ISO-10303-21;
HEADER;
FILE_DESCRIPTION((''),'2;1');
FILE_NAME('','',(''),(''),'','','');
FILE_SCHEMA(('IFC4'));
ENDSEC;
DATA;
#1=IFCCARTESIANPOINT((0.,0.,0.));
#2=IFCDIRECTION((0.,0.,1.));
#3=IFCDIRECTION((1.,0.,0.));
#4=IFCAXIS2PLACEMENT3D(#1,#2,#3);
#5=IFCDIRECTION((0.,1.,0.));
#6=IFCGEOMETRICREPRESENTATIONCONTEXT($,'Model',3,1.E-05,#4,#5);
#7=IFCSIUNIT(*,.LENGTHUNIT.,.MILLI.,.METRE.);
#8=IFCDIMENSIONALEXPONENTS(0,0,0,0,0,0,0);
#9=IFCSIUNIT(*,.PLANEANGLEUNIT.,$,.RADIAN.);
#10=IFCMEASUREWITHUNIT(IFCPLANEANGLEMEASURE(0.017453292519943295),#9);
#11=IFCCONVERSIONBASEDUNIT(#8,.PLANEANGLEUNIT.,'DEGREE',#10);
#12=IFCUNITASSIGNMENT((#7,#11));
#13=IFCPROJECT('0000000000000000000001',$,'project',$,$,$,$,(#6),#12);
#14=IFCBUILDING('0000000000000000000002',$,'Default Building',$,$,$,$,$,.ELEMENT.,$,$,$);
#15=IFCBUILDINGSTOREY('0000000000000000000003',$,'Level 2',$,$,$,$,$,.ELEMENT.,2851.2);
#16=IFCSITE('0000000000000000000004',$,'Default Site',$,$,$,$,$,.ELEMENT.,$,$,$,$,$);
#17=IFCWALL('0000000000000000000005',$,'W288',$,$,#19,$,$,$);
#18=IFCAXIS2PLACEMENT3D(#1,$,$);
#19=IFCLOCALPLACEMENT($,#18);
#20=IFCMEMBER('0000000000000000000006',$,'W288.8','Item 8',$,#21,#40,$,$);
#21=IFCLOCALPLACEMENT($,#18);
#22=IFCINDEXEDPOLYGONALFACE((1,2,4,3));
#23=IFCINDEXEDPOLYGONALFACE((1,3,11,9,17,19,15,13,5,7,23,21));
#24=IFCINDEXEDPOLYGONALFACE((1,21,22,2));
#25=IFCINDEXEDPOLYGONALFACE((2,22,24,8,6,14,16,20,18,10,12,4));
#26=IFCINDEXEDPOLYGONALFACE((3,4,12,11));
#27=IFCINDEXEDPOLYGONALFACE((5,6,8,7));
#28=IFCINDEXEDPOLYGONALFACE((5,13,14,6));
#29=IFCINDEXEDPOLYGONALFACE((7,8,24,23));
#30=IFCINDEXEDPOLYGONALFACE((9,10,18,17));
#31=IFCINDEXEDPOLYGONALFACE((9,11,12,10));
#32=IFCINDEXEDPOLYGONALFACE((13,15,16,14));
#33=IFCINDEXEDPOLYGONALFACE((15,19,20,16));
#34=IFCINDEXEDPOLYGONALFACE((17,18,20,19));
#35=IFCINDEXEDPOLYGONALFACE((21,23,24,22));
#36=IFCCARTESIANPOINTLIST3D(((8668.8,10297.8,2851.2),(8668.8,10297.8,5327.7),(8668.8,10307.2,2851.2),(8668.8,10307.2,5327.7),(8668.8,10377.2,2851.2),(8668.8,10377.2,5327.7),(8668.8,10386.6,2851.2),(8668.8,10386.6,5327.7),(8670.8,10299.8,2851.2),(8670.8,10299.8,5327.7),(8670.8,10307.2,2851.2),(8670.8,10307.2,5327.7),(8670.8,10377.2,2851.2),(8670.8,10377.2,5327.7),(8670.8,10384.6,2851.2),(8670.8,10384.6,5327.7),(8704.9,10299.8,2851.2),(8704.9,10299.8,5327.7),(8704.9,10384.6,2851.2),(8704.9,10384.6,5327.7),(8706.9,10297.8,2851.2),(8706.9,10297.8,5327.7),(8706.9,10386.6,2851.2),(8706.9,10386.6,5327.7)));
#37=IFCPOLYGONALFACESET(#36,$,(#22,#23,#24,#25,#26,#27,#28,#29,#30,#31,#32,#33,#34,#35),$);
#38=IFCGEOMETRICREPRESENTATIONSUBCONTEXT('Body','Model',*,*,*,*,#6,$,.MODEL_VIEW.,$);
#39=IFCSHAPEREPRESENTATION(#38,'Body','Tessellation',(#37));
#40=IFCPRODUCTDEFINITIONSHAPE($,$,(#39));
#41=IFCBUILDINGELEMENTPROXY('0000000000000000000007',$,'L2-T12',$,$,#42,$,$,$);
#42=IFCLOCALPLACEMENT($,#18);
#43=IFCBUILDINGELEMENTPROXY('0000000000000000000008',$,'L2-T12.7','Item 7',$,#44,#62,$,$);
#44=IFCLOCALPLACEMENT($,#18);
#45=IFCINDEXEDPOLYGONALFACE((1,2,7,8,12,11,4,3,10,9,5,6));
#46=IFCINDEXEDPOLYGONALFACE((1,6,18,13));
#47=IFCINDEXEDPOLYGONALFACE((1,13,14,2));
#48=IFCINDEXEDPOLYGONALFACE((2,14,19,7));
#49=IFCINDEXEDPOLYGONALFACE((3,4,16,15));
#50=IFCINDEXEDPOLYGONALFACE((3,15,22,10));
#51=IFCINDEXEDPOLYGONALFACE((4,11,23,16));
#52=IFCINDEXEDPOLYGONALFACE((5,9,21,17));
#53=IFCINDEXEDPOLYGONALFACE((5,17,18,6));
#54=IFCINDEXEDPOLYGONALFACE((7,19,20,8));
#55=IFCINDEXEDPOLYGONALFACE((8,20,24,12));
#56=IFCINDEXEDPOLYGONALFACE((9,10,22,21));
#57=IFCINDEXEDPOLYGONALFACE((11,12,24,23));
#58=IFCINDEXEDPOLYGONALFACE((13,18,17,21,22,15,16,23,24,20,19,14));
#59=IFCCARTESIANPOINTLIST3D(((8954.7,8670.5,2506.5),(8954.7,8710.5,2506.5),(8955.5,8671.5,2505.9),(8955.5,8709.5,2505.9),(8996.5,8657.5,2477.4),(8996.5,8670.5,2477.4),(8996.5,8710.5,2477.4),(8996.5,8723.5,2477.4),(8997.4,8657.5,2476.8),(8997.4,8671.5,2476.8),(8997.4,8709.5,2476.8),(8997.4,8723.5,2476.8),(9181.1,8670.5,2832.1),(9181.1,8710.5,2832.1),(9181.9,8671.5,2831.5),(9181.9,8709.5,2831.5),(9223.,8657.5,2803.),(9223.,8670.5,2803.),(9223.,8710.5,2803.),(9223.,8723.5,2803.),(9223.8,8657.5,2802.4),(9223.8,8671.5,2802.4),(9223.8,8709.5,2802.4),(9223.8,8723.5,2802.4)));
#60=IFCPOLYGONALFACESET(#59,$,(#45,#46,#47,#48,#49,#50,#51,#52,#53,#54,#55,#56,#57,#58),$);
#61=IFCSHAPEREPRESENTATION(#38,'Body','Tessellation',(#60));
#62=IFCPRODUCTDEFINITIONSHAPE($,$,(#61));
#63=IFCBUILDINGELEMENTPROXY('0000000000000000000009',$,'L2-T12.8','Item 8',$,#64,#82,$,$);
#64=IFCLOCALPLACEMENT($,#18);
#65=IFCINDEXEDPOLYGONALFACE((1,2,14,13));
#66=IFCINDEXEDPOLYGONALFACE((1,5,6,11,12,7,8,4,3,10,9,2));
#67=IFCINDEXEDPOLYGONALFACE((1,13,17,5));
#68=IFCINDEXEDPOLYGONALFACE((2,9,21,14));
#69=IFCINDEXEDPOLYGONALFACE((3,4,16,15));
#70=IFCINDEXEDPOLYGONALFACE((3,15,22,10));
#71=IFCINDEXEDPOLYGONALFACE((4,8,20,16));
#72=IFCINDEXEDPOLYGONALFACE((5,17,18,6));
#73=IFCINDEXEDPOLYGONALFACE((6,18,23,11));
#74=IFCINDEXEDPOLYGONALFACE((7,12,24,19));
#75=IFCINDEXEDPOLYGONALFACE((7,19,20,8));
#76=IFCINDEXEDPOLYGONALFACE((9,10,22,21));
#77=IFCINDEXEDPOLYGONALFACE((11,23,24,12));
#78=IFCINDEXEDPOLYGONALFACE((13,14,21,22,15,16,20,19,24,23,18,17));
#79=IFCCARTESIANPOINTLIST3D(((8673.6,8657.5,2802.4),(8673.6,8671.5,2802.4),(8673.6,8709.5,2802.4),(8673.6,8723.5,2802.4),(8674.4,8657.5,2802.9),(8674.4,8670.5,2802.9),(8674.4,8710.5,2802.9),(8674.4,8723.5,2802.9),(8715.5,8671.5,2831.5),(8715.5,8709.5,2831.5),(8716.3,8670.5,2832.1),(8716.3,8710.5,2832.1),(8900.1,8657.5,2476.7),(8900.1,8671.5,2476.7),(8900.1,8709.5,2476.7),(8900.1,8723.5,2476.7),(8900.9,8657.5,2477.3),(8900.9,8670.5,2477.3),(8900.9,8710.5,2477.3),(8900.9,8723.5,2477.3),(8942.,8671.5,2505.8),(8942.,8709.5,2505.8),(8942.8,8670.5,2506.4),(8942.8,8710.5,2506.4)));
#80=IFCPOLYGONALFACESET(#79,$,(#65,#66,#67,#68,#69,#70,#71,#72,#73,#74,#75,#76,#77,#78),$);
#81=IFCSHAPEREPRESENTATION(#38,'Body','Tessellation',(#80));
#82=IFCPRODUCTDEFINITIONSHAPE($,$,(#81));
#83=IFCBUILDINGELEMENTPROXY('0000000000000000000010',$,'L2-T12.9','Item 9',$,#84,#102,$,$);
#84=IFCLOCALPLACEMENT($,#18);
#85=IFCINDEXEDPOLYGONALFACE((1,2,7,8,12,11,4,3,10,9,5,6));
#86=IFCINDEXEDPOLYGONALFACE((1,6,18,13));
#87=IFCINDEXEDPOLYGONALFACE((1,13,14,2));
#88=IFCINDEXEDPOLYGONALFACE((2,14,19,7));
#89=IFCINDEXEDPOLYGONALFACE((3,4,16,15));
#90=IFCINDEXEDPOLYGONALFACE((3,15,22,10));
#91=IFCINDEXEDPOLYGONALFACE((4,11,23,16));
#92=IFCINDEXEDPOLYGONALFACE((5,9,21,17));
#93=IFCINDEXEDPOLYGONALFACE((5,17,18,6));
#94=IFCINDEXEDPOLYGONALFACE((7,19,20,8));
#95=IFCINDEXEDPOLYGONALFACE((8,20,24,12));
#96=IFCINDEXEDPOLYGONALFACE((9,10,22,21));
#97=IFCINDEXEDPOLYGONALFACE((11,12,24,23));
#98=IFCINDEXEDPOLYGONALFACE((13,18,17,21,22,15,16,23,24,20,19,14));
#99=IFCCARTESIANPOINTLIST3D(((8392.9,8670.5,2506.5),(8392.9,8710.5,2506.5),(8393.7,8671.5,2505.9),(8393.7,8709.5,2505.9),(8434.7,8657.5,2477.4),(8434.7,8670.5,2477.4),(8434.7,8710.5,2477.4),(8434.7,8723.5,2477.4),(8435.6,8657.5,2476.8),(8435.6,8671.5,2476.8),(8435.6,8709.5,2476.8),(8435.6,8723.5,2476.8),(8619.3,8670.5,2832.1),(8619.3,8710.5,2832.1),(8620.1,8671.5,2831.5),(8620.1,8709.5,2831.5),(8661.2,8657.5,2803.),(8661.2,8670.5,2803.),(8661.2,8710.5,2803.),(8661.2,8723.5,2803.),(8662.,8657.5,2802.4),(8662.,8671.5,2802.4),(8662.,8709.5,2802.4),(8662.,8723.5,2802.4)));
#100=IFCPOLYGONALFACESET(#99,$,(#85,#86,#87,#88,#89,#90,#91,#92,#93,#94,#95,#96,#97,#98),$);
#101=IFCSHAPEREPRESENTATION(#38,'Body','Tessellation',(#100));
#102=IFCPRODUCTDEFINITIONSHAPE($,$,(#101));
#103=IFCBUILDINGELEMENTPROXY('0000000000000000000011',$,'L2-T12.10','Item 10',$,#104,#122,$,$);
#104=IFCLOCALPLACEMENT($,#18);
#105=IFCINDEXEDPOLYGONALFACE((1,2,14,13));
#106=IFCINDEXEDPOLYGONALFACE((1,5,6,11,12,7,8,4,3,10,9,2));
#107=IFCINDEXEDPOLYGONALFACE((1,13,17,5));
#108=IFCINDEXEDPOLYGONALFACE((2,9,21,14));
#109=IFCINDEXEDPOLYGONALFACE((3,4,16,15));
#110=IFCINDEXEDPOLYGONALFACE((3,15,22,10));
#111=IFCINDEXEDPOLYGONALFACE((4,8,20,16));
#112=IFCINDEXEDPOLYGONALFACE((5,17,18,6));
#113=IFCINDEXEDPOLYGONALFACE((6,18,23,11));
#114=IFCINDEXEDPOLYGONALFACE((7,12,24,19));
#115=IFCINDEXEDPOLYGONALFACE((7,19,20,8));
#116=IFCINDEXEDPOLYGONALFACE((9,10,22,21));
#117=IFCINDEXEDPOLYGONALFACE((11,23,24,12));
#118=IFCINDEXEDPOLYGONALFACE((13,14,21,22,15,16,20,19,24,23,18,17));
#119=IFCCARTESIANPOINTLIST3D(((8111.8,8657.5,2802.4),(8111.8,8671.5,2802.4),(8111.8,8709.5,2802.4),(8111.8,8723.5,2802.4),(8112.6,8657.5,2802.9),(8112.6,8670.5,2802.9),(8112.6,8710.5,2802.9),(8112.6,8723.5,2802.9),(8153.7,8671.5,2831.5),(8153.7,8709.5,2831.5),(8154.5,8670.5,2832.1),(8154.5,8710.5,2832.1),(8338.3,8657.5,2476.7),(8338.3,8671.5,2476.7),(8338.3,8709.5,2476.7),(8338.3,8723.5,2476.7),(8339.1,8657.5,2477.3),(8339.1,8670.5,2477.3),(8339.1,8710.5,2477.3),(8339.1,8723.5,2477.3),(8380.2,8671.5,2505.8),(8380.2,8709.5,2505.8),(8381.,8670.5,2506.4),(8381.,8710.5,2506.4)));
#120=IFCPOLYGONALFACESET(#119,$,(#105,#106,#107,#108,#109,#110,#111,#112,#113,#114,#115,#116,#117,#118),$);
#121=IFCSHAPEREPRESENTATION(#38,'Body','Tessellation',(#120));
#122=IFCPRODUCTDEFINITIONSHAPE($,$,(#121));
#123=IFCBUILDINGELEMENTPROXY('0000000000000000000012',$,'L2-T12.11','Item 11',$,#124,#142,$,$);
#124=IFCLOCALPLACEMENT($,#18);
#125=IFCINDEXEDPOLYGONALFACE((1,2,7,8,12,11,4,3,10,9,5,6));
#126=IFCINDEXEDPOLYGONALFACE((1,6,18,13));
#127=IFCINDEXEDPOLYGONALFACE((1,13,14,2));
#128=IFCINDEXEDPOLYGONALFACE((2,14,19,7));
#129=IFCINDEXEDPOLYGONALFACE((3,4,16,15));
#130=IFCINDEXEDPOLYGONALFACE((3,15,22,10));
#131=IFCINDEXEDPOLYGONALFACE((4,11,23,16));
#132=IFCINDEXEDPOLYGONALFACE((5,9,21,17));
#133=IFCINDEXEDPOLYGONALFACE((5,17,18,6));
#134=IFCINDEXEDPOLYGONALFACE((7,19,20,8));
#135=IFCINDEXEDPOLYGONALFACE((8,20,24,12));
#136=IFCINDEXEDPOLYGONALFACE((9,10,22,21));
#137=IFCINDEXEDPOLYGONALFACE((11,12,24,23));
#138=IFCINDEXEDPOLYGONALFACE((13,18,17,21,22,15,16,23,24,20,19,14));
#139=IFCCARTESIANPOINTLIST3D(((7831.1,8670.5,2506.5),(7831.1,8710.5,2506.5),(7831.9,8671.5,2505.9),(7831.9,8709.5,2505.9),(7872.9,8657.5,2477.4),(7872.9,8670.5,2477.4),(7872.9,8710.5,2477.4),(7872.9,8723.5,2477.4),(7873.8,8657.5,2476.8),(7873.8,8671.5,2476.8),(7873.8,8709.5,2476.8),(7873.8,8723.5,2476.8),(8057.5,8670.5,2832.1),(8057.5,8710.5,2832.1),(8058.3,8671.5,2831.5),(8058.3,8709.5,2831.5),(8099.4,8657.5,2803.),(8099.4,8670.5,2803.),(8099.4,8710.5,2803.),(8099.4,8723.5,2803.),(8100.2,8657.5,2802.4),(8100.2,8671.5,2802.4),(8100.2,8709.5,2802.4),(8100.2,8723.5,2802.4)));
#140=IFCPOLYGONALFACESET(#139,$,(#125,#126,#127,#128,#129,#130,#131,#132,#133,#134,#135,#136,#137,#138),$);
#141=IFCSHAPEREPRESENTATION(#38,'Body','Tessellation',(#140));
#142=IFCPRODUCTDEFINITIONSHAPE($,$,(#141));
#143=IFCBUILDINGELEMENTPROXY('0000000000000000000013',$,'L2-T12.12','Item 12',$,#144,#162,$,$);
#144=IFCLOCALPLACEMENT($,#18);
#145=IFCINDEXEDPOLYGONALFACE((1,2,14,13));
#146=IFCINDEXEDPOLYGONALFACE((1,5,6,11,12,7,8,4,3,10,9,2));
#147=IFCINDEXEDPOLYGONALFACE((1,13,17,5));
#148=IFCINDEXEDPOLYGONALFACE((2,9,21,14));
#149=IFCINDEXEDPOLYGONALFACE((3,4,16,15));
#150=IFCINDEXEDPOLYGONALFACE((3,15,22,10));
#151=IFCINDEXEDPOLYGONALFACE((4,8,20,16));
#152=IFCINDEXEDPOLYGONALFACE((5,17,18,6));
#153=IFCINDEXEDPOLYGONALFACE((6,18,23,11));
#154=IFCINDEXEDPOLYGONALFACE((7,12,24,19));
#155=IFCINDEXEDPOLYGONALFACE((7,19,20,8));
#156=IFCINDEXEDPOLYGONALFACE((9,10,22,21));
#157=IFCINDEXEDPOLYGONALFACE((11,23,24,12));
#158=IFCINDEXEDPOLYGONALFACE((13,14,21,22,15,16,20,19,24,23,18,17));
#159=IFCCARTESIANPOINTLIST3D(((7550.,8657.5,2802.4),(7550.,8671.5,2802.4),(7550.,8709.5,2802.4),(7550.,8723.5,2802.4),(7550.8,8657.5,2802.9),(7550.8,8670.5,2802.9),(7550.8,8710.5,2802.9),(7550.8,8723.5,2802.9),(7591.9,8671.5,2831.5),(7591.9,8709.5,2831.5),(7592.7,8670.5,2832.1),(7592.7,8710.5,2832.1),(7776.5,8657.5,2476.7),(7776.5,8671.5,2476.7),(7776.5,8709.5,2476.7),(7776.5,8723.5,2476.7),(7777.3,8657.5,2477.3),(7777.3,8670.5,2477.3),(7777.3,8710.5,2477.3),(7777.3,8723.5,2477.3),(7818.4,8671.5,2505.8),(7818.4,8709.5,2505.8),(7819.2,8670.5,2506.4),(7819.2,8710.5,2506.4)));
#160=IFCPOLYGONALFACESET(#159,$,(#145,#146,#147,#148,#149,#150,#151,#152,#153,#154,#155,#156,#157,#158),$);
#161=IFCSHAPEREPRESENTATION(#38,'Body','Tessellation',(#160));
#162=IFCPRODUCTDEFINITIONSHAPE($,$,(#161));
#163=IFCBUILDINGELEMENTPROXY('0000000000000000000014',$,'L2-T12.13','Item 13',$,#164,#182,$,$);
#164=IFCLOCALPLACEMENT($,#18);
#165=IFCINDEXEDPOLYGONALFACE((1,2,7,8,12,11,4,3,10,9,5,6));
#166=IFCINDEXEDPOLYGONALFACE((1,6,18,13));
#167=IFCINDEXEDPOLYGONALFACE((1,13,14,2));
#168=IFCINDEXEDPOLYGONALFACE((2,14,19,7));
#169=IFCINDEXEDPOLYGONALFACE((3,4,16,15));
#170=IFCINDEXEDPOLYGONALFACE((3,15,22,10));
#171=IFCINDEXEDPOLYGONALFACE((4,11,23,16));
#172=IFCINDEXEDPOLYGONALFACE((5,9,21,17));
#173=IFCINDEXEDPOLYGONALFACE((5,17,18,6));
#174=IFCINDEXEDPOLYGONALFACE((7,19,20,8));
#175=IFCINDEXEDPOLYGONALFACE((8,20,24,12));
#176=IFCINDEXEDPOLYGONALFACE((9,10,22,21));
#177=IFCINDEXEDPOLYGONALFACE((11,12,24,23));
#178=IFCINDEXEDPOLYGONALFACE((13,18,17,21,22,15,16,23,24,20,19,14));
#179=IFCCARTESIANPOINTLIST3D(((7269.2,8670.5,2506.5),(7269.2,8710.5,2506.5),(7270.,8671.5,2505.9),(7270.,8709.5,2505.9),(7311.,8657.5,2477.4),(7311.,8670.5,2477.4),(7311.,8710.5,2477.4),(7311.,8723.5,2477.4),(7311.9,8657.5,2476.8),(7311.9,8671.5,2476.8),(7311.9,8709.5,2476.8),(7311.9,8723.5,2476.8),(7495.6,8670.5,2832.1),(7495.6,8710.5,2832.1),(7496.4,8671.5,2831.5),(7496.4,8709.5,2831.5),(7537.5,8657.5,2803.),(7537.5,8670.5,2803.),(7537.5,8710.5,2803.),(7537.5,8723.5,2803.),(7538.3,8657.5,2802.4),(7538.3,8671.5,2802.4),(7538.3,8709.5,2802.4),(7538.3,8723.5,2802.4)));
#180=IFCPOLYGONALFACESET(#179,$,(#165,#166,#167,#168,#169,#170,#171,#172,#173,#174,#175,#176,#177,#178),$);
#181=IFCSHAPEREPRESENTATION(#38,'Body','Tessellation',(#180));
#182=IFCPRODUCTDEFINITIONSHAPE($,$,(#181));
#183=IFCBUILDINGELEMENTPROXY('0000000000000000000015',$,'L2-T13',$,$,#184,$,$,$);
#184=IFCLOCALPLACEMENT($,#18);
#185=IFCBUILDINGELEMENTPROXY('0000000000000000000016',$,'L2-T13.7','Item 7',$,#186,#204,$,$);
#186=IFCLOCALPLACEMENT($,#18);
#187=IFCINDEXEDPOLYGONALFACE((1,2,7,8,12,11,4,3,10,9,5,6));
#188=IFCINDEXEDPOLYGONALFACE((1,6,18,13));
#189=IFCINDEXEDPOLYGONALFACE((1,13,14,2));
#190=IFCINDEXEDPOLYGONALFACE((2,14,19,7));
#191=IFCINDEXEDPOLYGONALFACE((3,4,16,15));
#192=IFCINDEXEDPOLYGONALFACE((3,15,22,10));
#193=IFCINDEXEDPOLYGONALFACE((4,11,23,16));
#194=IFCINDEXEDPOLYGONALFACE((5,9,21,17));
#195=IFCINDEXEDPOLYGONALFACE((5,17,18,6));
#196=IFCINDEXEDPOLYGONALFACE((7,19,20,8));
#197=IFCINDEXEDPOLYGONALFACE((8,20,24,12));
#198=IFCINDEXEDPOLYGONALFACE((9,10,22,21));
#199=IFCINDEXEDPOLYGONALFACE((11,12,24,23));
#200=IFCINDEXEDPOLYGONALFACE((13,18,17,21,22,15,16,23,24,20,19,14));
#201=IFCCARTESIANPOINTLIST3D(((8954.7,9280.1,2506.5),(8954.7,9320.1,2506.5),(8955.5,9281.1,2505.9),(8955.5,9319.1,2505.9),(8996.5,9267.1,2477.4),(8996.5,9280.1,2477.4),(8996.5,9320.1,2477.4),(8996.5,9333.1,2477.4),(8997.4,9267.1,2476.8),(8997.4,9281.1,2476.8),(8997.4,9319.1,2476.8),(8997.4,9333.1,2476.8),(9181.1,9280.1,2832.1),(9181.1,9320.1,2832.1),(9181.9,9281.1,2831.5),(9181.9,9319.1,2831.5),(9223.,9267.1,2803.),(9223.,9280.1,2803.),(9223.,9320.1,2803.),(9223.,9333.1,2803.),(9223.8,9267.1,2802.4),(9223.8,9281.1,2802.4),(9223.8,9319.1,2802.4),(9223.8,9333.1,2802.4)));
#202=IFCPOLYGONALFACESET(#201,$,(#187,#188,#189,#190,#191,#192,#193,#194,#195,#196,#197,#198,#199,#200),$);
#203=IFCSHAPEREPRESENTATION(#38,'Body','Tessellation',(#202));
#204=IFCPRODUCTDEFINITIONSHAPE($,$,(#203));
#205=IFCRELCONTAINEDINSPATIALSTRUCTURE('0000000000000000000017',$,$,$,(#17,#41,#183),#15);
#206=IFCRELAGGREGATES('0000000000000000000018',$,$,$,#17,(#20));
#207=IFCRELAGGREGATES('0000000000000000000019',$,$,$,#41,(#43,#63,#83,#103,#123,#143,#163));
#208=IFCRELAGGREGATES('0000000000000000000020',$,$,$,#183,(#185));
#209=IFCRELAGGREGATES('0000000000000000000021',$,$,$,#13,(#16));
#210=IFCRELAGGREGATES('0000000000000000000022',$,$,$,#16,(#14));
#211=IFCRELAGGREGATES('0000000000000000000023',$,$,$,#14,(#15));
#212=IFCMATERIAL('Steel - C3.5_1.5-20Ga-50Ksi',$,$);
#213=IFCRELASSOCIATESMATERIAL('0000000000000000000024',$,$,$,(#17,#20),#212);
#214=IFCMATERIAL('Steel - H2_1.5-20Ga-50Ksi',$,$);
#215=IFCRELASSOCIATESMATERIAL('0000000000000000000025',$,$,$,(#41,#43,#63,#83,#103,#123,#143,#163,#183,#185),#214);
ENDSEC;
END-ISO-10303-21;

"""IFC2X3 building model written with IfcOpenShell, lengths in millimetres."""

from ifc_helpers import new_model, entity, si_unit, converted_unit, direction, frame, origin, origin_with_axes, origin_2d_with_axis, place, context, subcontext, project, spatial, polyline, c_section, outline, extrude, material, element, aggregate, save


model = new_model("IFC2X3")

# Units and contexts
model_context = context("Model", 3, precision=1e-05, world=origin_with_axes(), true_north=direction((0.0, 1.0, 0.0)))
body_context = subcontext(model_context, "Body", "Model", "MODEL_VIEW")
ifc_project = project(units=[si_unit("LENGTHUNIT", "METRE", prefix="MILLI"), converted_unit("PLANEANGLEUNIT", "DEGREE", entity("IfcPlaneAngleMeasure", 0.017453292519943295), si_unit("PLANEANGLEUNIT", "RADIAN"), dimensions=[0, 0, 0, 0, 0, 0, 0])], contexts=[model_context])

# Site, building, storey
site = spatial("IfcSite", under=ifc_project, Name="Default Site", CompositionType="ELEMENT")
building = spatial("IfcBuilding", under=site, Name="Default Building", CompositionType="ELEMENT")
storey = spatial("IfcBuildingStorey", under=building, Name="Level 2", CompositionType="ELEMENT", Elevation=2851.2)

# Wall, member
ifc_material_1 = material(Name="Steel - C3.5_1.5-20Ga-50Ksi")
wall = element("IfcWall", 1, inside=storey, material=ifc_material_1, Name="W288")
member_placement = place(None, frame((8687.9, 10342.2, 2851.2), z_axis=(0.0, 0.0, 1.0), x_axis=(-1.0, 0.0, 0.0)))
member = element("IfcMember", 2, at=member_placement, material=ifc_material_1, Name="W288.8", Description="Item 8", context=body_context, shape_type="SweptSolid", body=[
    extrude(c_section(Depth=88.9, Width=38.1, WallThickness=2.0, Girth=9.5, at=origin_2d_with_axis()), origin(), (0.0, 0.0, 1.0), 2476.5),
])
aggregate(wall, [member])

# Building element proxies
ifc_material_2 = material(Name="Steel - H2_1.5-20Ga-50Ksi")
proxy_1 = element("IfcBuildingElementProxy", 3, inside=storey, material=ifc_material_2, Name="L2-T12")
proxy_2_placement = place(None, frame((9223.8, 8723.5, 2802.4), z_axis=(-0.571, 0.0, -0.821), x_axis=(0.0, -40.0, 0.0)))
proxy_2 = element("IfcBuildingElementProxy", 4, at=proxy_2_placement, material=ifc_material_2, Name="L2-T12.7", Description="Item 7", context=body_context, shape_type="SweptSolid", body=[
    extrude(outline(polyline([(0.0, 0.0), (14.0, 0.0), (14.0, 51.0), (52.0, 51.0), (52.0, 0.0), (66.0, 0.0), (66.0, 1.0), (53.0, 1.0), (53.0, 52.0), (13.0, 52.0), (13.0, 1.0), (0.0, 1.0), (0.0, 0.0)])), origin(), (0.0, 0.0, 1.0), 396.6),
])
proxy_3_placement = place(None, frame((8900.1, 8723.5, 2476.7), z_axis=(-0.571, 0.0, 0.821), x_axis=(0.0, -40.0, 0.0)))
proxy_3 = element("IfcBuildingElementProxy", 5, at=proxy_3_placement, material=ifc_material_2, Name="L2-T12.8", Description="Item 8", context=body_context, shape_type="SweptSolid", body=[
    extrude(outline(polyline([(0.0, 0.0), (14.0, 0.0), (14.0, 51.0), (52.0, 51.0), (52.0, 0.0), (66.0, 0.0), (66.0, 1.0), (53.0, 1.0), (53.0, 52.0), (13.0, 52.0), (13.0, 1.0), (0.0, 1.0), (0.0, 0.0)])), origin(), (0.0, 0.0, 1.0), 396.7),
])
proxy_4_placement = place(None, frame((8662.0, 8723.5, 2802.4), z_axis=(-0.571, 0.0, -0.821), x_axis=(0.0, -40.0, 0.0)))
proxy_4 = element("IfcBuildingElementProxy", 6, at=proxy_4_placement, material=ifc_material_2, Name="L2-T12.9", Description="Item 9", context=body_context, shape_type="SweptSolid", body=[
    extrude(outline(polyline([(0.0, 0.0), (14.0, 0.0), (14.0, 51.0), (52.0, 51.0), (52.0, 0.0), (66.0, 0.0), (66.0, 1.0), (53.0, 1.0), (53.0, 52.0), (13.0, 52.0), (13.0, 1.0), (0.0, 1.0), (0.0, 0.0)])), origin(), (0.0, 0.0, 1.0), 396.6),
])
proxy_5_placement = place(None, frame((8338.3, 8723.5, 2476.7), z_axis=(-0.571, 0.0, 0.821), x_axis=(0.0, -40.0, 0.0)))
proxy_5 = element("IfcBuildingElementProxy", 7, at=proxy_5_placement, material=ifc_material_2, Name="L2-T12.10", Description="Item 10", context=body_context, shape_type="SweptSolid", body=[
    extrude(outline(polyline([(0.0, 0.0), (14.0, 0.0), (14.0, 51.0), (52.0, 51.0), (52.0, 0.0), (66.0, 0.0), (66.0, 1.0), (53.0, 1.0), (53.0, 52.0), (13.0, 52.0), (13.0, 1.0), (0.0, 1.0), (0.0, 0.0)])), origin(), (0.0, 0.0, 1.0), 396.7),
])
proxy_6_placement = place(None, frame((8100.2, 8723.5, 2802.4), z_axis=(-0.571, 0.0, -0.821), x_axis=(0.0, -40.0, 0.0)))
proxy_6 = element("IfcBuildingElementProxy", 8, at=proxy_6_placement, material=ifc_material_2, Name="L2-T12.11", Description="Item 11", context=body_context, shape_type="SweptSolid", body=[
    extrude(outline(polyline([(0.0, 0.0), (14.0, 0.0), (14.0, 51.0), (52.0, 51.0), (52.0, 0.0), (66.0, 0.0), (66.0, 1.0), (53.0, 1.0), (53.0, 52.0), (13.0, 52.0), (13.0, 1.0), (0.0, 1.0), (0.0, 0.0)])), origin(), (0.0, 0.0, 1.0), 396.6),
])
proxy_7_placement = place(None, frame((7776.5, 8723.5, 2476.7), z_axis=(-0.571, 0.0, 0.821), x_axis=(0.0, -40.0, 0.0)))
proxy_7 = element("IfcBuildingElementProxy", 9, at=proxy_7_placement, material=ifc_material_2, Name="L2-T12.12", Description="Item 12", context=body_context, shape_type="SweptSolid", body=[
    extrude(outline(polyline([(0.0, 0.0), (14.0, 0.0), (14.0, 51.0), (52.0, 51.0), (52.0, 0.0), (66.0, 0.0), (66.0, 1.0), (53.0, 1.0), (53.0, 52.0), (13.0, 52.0), (13.0, 1.0), (0.0, 1.0), (0.0, 0.0)])), origin(), (0.0, 0.0, 1.0), 396.7),
])
proxy_8_placement = place(None, frame((7538.3, 8723.5, 2802.4), z_axis=(-0.571, 0.0, -0.821), x_axis=(0.0, -40.0, 0.0)))
proxy_8 = element("IfcBuildingElementProxy", 10, at=proxy_8_placement, material=ifc_material_2, Name="L2-T12.13", Description="Item 13", context=body_context, shape_type="SweptSolid", body=[
    extrude(outline(polyline([(0.0, 0.0), (14.0, 0.0), (14.0, 51.0), (52.0, 51.0), (52.0, 0.0), (66.0, 0.0), (66.0, 1.0), (53.0, 1.0), (53.0, 52.0), (13.0, 52.0), (13.0, 1.0), (0.0, 1.0), (0.0, 0.0)])), origin(), (0.0, 0.0, 1.0), 396.6),
])
aggregate(proxy_1, [proxy_2, proxy_3, proxy_4, proxy_5, proxy_6, proxy_7, proxy_8])
proxy_9 = element("IfcBuildingElementProxy", 11, inside=storey, material=ifc_material_2, Name="L2-T13")
proxy_10_placement = place(None, frame((9223.8, 9333.1, 2802.4), z_axis=(-0.571, 0.0, -0.821), x_axis=(0.0, -40.0, 0.0)))
proxy_10 = element("IfcBuildingElementProxy", 12, at=proxy_10_placement, material=ifc_material_2, Name="L2-T13.7", Description="Item 7", context=body_context, shape_type="SweptSolid", body=[
    extrude(outline(polyline([(0.0, 0.0), (14.0, 0.0), (14.0, 51.0), (52.0, 51.0), (52.0, 0.0), (66.0, 0.0), (66.0, 1.0), (53.0, 1.0), (53.0, 52.0), (13.0, 52.0), (13.0, 1.0), (0.0, 1.0), (0.0, 0.0)])), origin(), (0.0, 0.0, 1.0), 396.6),
])
aggregate(proxy_9, [proxy_10])

save(model, "model.ifc")
